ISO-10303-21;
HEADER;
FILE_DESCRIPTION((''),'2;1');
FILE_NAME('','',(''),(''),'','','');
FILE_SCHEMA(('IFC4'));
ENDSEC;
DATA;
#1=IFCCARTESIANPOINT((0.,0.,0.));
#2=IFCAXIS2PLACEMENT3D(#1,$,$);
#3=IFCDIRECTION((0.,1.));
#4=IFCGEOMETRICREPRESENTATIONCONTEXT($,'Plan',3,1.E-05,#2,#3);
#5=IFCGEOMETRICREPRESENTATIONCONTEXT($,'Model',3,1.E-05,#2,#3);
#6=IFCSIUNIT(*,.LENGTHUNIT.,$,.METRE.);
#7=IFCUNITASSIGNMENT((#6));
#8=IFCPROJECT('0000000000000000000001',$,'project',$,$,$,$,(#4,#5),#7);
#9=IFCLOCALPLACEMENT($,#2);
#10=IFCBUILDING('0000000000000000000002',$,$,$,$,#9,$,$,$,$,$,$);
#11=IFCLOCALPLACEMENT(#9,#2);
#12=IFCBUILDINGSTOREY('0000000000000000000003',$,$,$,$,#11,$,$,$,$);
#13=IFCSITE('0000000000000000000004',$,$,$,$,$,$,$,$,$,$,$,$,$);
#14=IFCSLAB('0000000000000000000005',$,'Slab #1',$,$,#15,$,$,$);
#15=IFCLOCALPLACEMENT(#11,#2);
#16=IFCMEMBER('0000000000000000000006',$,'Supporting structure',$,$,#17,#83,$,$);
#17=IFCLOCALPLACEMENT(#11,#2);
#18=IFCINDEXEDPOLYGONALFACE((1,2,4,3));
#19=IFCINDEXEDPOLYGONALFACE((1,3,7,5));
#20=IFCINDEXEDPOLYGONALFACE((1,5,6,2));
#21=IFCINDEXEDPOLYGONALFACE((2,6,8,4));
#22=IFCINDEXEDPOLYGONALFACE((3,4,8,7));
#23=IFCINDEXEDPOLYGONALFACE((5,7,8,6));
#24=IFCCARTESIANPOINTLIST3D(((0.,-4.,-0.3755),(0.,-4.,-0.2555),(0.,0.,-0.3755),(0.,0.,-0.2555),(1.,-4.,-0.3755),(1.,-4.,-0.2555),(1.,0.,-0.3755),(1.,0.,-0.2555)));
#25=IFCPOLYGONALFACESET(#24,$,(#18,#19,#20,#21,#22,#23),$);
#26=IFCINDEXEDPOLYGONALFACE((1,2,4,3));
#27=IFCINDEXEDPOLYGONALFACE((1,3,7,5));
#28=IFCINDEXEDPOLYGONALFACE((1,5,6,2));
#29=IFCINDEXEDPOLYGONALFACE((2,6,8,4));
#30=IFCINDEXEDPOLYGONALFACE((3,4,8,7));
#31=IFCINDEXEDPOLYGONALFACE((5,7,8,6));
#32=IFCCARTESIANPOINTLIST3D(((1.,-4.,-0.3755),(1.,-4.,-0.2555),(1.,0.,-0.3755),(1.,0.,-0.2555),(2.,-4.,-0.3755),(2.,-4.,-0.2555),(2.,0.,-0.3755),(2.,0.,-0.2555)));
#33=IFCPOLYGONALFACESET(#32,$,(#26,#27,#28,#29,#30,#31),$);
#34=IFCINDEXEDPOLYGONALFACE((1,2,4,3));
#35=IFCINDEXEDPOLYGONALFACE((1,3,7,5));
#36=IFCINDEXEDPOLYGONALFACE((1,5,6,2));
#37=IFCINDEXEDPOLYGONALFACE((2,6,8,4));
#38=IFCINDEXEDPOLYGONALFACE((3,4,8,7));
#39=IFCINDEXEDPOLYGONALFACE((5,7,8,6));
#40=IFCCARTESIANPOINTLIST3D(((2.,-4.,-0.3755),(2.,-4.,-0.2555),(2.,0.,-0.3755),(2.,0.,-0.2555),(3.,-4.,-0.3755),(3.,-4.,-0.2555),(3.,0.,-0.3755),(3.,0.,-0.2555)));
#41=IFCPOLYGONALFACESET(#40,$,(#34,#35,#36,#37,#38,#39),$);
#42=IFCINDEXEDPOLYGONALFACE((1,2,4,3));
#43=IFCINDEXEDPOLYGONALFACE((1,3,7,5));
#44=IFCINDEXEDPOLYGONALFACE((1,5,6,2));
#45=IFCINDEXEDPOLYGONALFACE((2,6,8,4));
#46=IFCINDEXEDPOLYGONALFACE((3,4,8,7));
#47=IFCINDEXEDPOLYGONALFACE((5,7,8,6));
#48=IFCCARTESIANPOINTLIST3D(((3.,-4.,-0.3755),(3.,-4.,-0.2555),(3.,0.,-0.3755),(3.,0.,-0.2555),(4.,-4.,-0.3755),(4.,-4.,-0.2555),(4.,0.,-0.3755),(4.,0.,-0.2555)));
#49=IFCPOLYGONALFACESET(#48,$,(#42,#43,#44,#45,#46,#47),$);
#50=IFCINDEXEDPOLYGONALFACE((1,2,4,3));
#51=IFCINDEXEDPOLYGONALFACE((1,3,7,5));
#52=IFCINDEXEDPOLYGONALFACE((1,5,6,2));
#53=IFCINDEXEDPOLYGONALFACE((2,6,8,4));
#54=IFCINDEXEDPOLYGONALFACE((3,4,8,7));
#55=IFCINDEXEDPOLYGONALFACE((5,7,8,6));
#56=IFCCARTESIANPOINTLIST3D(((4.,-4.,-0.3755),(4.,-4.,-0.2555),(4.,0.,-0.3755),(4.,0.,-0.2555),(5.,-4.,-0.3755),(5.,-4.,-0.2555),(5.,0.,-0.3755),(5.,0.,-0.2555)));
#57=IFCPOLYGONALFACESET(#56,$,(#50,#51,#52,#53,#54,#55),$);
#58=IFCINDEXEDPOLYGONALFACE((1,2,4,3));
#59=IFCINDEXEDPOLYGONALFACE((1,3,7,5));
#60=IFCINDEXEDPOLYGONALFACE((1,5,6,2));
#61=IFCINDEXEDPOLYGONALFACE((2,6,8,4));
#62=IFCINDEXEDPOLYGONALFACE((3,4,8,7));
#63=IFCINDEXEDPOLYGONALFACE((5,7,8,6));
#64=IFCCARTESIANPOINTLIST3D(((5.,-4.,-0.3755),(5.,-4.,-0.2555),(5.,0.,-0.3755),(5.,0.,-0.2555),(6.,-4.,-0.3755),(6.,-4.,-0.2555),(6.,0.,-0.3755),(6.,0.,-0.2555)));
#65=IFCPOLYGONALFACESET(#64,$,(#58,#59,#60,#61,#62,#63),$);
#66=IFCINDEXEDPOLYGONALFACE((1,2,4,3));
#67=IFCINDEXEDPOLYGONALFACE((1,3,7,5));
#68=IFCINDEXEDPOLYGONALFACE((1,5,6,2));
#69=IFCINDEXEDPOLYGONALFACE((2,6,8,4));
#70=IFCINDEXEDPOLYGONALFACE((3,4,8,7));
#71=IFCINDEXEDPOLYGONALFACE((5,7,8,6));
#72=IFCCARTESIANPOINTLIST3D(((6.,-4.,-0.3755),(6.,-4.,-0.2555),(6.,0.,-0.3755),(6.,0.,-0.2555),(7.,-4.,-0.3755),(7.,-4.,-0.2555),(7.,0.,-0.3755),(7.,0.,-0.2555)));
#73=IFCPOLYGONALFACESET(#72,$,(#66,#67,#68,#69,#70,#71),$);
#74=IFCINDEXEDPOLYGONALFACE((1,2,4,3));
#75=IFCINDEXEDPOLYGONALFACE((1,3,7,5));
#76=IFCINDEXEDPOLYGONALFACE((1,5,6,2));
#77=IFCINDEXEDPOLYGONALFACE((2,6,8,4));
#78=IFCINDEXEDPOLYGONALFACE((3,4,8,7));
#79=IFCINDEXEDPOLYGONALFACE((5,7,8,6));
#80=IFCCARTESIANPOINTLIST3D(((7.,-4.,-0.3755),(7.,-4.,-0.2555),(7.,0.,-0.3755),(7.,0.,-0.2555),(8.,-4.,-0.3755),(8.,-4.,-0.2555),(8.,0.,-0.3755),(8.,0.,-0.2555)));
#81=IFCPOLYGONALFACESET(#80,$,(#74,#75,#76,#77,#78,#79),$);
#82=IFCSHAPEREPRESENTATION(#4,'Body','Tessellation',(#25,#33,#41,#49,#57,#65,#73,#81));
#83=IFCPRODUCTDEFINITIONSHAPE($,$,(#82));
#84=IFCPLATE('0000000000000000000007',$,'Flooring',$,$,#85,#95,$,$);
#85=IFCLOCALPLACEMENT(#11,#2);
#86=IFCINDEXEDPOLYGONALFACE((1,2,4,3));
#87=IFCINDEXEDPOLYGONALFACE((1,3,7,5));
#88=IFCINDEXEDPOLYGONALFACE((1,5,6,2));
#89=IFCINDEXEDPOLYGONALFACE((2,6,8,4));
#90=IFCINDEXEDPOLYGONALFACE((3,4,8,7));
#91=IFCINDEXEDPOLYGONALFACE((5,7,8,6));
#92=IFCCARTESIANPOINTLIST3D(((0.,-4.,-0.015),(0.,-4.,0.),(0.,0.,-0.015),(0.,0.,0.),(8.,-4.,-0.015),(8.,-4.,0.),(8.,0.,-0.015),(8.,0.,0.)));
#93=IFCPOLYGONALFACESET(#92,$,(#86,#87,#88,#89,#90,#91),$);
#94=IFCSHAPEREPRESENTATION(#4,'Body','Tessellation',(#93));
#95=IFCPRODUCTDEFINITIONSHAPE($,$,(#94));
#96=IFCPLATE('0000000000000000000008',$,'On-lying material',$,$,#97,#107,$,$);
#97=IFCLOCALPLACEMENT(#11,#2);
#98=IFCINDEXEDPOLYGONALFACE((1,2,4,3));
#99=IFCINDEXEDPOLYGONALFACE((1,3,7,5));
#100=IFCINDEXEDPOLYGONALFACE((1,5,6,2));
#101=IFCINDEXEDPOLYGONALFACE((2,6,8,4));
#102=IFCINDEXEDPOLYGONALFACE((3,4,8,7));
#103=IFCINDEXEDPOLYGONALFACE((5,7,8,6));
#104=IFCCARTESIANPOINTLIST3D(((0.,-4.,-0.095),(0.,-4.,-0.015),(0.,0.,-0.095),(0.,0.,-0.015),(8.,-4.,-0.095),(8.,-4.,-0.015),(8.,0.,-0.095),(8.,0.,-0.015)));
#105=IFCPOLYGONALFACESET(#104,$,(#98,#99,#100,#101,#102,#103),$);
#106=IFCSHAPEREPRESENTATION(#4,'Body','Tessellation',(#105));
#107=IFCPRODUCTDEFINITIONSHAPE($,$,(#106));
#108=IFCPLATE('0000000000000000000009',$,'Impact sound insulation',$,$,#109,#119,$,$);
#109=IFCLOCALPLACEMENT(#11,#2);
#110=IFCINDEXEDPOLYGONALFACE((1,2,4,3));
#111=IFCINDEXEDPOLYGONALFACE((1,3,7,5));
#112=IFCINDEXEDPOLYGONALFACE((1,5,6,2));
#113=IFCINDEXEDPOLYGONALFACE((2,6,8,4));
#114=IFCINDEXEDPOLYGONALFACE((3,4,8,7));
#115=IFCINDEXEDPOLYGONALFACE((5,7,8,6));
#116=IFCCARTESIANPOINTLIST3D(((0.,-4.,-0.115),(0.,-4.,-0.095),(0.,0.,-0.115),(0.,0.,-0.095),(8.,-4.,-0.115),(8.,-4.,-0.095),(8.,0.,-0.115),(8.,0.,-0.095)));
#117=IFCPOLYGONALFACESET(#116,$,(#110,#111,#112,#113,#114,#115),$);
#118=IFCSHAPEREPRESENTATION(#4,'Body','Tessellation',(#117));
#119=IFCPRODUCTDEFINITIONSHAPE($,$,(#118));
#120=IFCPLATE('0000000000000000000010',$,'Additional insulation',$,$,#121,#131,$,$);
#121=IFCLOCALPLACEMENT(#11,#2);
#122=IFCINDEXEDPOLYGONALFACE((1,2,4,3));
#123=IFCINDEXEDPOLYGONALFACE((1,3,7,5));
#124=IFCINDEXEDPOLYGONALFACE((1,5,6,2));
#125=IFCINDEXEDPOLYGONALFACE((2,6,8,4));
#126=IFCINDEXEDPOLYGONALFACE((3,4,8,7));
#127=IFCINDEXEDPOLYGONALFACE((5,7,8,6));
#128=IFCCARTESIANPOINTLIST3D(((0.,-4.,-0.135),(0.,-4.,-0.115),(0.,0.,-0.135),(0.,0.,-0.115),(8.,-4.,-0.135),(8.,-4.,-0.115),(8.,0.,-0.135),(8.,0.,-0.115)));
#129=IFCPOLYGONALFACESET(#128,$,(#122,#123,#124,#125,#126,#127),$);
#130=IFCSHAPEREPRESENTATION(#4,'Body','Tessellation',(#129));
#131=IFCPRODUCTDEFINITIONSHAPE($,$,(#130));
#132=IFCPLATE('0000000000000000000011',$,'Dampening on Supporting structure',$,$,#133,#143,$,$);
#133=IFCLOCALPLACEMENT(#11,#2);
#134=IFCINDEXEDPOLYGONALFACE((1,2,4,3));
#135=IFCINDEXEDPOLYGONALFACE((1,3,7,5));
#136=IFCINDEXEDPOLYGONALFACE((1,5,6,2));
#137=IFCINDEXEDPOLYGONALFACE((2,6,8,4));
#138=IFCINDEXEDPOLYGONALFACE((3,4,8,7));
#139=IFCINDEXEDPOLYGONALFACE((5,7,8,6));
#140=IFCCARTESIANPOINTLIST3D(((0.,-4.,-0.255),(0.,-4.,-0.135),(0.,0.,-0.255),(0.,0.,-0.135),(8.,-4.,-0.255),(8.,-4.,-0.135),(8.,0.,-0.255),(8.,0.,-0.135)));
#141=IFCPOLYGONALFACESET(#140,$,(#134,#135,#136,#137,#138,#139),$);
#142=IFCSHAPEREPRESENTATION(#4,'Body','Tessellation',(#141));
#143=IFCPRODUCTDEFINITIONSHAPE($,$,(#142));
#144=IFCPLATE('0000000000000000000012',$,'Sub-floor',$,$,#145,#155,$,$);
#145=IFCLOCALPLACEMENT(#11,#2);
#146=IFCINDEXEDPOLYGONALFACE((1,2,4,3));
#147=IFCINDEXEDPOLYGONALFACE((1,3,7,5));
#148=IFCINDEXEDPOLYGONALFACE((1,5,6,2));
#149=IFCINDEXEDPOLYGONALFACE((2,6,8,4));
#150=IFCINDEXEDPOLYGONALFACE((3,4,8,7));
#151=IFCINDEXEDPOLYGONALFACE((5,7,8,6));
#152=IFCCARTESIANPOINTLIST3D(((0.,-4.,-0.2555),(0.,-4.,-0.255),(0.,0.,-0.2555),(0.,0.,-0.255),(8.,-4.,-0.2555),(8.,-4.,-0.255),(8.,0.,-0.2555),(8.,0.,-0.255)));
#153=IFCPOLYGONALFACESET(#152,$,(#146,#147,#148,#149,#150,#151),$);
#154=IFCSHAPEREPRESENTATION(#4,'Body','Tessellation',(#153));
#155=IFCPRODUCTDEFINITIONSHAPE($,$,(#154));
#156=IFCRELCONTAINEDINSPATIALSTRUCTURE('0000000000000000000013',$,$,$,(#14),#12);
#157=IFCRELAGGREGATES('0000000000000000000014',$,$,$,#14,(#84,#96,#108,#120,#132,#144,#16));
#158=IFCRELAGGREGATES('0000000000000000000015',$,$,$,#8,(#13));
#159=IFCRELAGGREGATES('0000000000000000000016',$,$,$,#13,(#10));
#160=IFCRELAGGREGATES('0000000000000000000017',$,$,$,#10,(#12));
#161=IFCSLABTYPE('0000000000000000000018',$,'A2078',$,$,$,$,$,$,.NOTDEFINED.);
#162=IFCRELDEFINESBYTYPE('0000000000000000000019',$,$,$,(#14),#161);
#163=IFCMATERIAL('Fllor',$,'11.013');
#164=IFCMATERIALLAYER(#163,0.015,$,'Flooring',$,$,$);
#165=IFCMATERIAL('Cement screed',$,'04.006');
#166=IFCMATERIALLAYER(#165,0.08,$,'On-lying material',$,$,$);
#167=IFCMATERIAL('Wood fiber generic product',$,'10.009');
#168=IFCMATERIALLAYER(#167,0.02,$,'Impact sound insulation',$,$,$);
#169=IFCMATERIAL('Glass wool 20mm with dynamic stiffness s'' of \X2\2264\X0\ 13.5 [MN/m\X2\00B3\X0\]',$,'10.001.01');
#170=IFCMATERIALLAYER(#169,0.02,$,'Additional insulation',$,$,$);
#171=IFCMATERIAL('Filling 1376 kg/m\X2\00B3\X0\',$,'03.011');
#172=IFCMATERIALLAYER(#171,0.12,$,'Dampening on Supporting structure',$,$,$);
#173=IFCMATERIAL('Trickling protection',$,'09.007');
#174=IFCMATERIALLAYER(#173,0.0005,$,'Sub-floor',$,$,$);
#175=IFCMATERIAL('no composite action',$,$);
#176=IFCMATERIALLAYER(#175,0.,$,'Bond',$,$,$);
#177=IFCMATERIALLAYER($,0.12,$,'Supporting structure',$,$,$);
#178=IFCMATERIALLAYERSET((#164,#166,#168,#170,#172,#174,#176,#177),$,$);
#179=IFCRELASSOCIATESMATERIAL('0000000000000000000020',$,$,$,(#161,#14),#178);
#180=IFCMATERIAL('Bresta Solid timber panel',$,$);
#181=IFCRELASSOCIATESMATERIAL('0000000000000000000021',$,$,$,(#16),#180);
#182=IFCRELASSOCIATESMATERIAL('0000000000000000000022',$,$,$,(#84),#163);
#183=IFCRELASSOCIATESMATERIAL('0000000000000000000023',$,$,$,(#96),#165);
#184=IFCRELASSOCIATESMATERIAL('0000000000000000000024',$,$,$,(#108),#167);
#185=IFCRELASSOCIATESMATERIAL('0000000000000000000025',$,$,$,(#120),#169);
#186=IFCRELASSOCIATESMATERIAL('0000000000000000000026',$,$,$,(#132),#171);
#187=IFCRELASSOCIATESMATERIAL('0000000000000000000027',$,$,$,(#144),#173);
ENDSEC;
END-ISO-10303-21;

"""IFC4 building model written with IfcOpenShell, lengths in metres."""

from ifc_helpers import new_model, si_unit, direction, frame, frame_2d, origin, origin_with_axes, place, context, project, spatial, rectangle, extrude, material, layer, layer_set, type_object, element, aggregate, save


model = new_model("IFC4")

# Units and contexts
plan_context = context("Plan", 3, precision=1e-05, world=origin(), true_north=direction((0.0, 1.0)))
model_context = context("Model", 3, precision=1e-05, world=origin(), true_north=direction((0.0, 1.0)))
ifc_project = project(units=[si_unit("LENGTHUNIT", "METRE")], contexts=[plan_context, model_context])

# Site, building, storey
site = spatial("IfcSite", under=ifc_project)
building_placement = place(None, origin())
building = spatial("IfcBuilding", under=site, at=building_placement)
storey_placement = place(building_placement, origin())
storey = spatial("IfcBuildingStorey", under=building, at=storey_placement)

# Slab, member, plates
ifc_material_1 = material(Name="Fllor", Category="11.013")
ifc_layer_1 = layer(ifc_material_1, 0.015, Name="Flooring")
ifc_material_2 = material(Name="Cement screed", Category="04.006")
ifc_layer_2 = layer(ifc_material_2, 0.08, Name="On-lying material")
ifc_material_3 = material(Name="Wood fiber generic product", Category="10.009")
ifc_layer_3 = layer(ifc_material_3, 0.02, Name="Impact sound insulation")
ifc_material_4 = material(Name="Glass wool 20mm with dynamic stiffness s' of ≤ 13.5 [MN/m³]", Category="10.001.01")
ifc_layer_4 = layer(ifc_material_4, 0.02, Name="Additional insulation")
ifc_material_5 = material(Name="Filling 1376 kg/m³", Category="03.011")
ifc_layer_5 = layer(ifc_material_5, 0.12, Name="Dampening on Supporting structure")
ifc_material_6 = material(Name="Trickling protection", Category="09.007")
ifc_layer_6 = layer(ifc_material_6, 0.0005, Name="Sub-floor")
ifc_material_7 = material(Name="no composite action")
ifc_layer_7 = layer(ifc_material_7, 0.0, Name="Bond")
ifc_layer_8 = layer(None, 0.12, Name="Supporting structure")
ifc_layer_set = layer_set([ifc_layer_1, ifc_layer_2, ifc_layer_3, ifc_layer_4, ifc_layer_5, ifc_layer_6, ifc_layer_7, ifc_layer_8])
slab_type = type_object("IfcSlabType", Name="A2078", PredefinedType="NOTDEFINED", material=ifc_layer_set)
slab_placement = place(None, frame((0.0, 0.0, 0.0), z_axis=(0.0, 0.0, -1.0), x_axis=(1.0, 0.0, 0.0)))
slab = element("IfcSlab", 1, at=slab_placement, inside=storey, type_object=slab_type, material=ifc_layer_set, Name="Slab #1")
ifc_material_8 = material(Name="Bresta Solid timber panel")
member_placement = place(slab_placement, origin())
member = element("IfcMember", 2, at=member_placement, material=ifc_material_8, Name="Supporting structure", context=plan_context, shape_type="SweptSolid", body=[
    extrude(rectangle(XDim=1.0, YDim=0.12, at=frame_2d((0.5, 0.06), x_axis=(1.0, 0.0))), frame((0.0, 4.0, 0.2555), z_axis=(0.0, -1.0, 0.0), x_axis=(1.0, 0.0, 0.0)), (0.0, 0.0, 1.0), 4.0),
    extrude(rectangle(XDim=1.0, YDim=0.12, at=frame_2d((0.5, 0.06), x_axis=(1.0, 0.0))), frame((1.0, 4.0, 0.2555), z_axis=(0.0, -1.0, 0.0), x_axis=(1.0, 0.0, 0.0)), (0.0, 0.0, 1.0), 4.0),
    extrude(rectangle(XDim=1.0, YDim=0.12, at=frame_2d((0.5, 0.06), x_axis=(1.0, 0.0))), frame((2.0, 4.0, 0.2555), z_axis=(0.0, -1.0, 0.0), x_axis=(1.0, 0.0, 0.0)), (0.0, 0.0, 1.0), 4.0),
    extrude(rectangle(XDim=1.0, YDim=0.12, at=frame_2d((0.5, 0.06), x_axis=(1.0, 0.0))), frame((3.0, 4.0, 0.2555), z_axis=(0.0, -1.0, 0.0), x_axis=(1.0, 0.0, 0.0)), (0.0, 0.0, 1.0), 4.0),
    extrude(rectangle(XDim=1.0, YDim=0.12, at=frame_2d((0.5, 0.06), x_axis=(1.0, 0.0))), frame((4.0, 4.0, 0.2555), z_axis=(0.0, -1.0, 0.0), x_axis=(1.0, 0.0, 0.0)), (0.0, 0.0, 1.0), 4.0),
    extrude(rectangle(XDim=1.0, YDim=0.12, at=frame_2d((0.5, 0.06), x_axis=(1.0, 0.0))), frame((5.0, 4.0, 0.2555), z_axis=(0.0, -1.0, 0.0), x_axis=(1.0, 0.0, 0.0)), (0.0, 0.0, 1.0), 4.0),
    extrude(rectangle(XDim=1.0, YDim=0.12, at=frame_2d((0.5, 0.06), x_axis=(1.0, 0.0))), frame((6.0, 4.0, 0.2555), z_axis=(0.0, -1.0, 0.0), x_axis=(1.0, 0.0, 0.0)), (0.0, 0.0, 1.0), 4.0),
    extrude(rectangle(XDim=1.0, YDim=0.12, at=frame_2d((0.5, 0.06), x_axis=(1.0, 0.0))), frame((7.0, 4.0, 0.2555), z_axis=(0.0, -1.0, 0.0), x_axis=(1.0, 0.0, 0.0)), (0.0, 0.0, 1.0), 4.0),
])
plate_1_placement = place(slab_placement, origin())
plate_1 = element("IfcPlate", 3, at=plate_1_placement, material=ifc_material_1, Name="Flooring", context=plan_context, shape_type="SweptSolid", body=[
    extrude(rectangle(XDim=8.0, YDim=4.0, at=frame_2d((4.0, 2.0), x_axis=(1.0, 0.0))), origin_with_axes(), (0.0, 0.0, 1.0), 0.015),
])
plate_2_placement = place(slab_placement, origin())
plate_2 = element("IfcPlate", 4, at=plate_2_placement, material=ifc_material_2, Name="On-lying material", context=plan_context, shape_type="SweptSolid", body=[
    extrude(rectangle(XDim=8.0, YDim=4.0, at=frame_2d((4.0, 2.0), x_axis=(1.0, 0.0))), frame((0.0, 0.0, 0.015), z_axis=(0.0, 0.0, 1.0), x_axis=(1.0, 0.0, 0.0)), (0.0, 0.0, 1.0), 0.08),
])
plate_3_placement = place(slab_placement, origin())
plate_3 = element("IfcPlate", 5, at=plate_3_placement, material=ifc_material_3, Name="Impact sound insulation", context=plan_context, shape_type="SweptSolid", body=[
    extrude(rectangle(XDim=8.0, YDim=4.0, at=frame_2d((4.0, 2.0), x_axis=(1.0, 0.0))), frame((0.0, 0.0, 0.095), z_axis=(0.0, 0.0, 1.0), x_axis=(1.0, 0.0, 0.0)), (0.0, 0.0, 1.0), 0.02),
])
plate_4_placement = place(slab_placement, origin())
plate_4 = element("IfcPlate", 6, at=plate_4_placement, material=ifc_material_4, Name="Additional insulation", context=plan_context, shape_type="SweptSolid", body=[
    extrude(rectangle(XDim=8.0, YDim=4.0, at=frame_2d((4.0, 2.0), x_axis=(1.0, 0.0))), frame((0.0, 0.0, 0.115), z_axis=(0.0, 0.0, 1.0), x_axis=(1.0, 0.0, 0.0)), (0.0, 0.0, 1.0), 0.02),
])
plate_5_placement = place(slab_placement, origin())
plate_5 = element("IfcPlate", 7, at=plate_5_placement, material=ifc_material_5, Name="Dampening on Supporting structure", context=plan_context, shape_type="SweptSolid", body=[
    extrude(rectangle(XDim=8.0, YDim=4.0, at=frame_2d((4.0, 2.0), x_axis=(1.0, 0.0))), frame((0.0, 0.0, 0.135), z_axis=(0.0, 0.0, 1.0), x_axis=(1.0, 0.0, 0.0)), (0.0, 0.0, 1.0), 0.12),
])
plate_6_placement = place(slab_placement, origin())
plate_6 = element("IfcPlate", 8, at=plate_6_placement, material=ifc_material_6, Name="Sub-floor", context=plan_context, shape_type="SweptSolid", body=[
    extrude(rectangle(XDim=8.0, YDim=4.0, at=frame_2d((4.0, 2.0), x_axis=(1.0, 0.0))), frame((0.0, 0.0, 0.255), z_axis=(0.0, 0.0, 1.0), x_axis=(1.0, 0.0, 0.0)), (0.0, 0.0, 1.0), 0.0005),
])
aggregate(slab, [plate_1, plate_2, plate_3, plate_4, plate_5, plate_6, member])

save(model, "model.ifc")
